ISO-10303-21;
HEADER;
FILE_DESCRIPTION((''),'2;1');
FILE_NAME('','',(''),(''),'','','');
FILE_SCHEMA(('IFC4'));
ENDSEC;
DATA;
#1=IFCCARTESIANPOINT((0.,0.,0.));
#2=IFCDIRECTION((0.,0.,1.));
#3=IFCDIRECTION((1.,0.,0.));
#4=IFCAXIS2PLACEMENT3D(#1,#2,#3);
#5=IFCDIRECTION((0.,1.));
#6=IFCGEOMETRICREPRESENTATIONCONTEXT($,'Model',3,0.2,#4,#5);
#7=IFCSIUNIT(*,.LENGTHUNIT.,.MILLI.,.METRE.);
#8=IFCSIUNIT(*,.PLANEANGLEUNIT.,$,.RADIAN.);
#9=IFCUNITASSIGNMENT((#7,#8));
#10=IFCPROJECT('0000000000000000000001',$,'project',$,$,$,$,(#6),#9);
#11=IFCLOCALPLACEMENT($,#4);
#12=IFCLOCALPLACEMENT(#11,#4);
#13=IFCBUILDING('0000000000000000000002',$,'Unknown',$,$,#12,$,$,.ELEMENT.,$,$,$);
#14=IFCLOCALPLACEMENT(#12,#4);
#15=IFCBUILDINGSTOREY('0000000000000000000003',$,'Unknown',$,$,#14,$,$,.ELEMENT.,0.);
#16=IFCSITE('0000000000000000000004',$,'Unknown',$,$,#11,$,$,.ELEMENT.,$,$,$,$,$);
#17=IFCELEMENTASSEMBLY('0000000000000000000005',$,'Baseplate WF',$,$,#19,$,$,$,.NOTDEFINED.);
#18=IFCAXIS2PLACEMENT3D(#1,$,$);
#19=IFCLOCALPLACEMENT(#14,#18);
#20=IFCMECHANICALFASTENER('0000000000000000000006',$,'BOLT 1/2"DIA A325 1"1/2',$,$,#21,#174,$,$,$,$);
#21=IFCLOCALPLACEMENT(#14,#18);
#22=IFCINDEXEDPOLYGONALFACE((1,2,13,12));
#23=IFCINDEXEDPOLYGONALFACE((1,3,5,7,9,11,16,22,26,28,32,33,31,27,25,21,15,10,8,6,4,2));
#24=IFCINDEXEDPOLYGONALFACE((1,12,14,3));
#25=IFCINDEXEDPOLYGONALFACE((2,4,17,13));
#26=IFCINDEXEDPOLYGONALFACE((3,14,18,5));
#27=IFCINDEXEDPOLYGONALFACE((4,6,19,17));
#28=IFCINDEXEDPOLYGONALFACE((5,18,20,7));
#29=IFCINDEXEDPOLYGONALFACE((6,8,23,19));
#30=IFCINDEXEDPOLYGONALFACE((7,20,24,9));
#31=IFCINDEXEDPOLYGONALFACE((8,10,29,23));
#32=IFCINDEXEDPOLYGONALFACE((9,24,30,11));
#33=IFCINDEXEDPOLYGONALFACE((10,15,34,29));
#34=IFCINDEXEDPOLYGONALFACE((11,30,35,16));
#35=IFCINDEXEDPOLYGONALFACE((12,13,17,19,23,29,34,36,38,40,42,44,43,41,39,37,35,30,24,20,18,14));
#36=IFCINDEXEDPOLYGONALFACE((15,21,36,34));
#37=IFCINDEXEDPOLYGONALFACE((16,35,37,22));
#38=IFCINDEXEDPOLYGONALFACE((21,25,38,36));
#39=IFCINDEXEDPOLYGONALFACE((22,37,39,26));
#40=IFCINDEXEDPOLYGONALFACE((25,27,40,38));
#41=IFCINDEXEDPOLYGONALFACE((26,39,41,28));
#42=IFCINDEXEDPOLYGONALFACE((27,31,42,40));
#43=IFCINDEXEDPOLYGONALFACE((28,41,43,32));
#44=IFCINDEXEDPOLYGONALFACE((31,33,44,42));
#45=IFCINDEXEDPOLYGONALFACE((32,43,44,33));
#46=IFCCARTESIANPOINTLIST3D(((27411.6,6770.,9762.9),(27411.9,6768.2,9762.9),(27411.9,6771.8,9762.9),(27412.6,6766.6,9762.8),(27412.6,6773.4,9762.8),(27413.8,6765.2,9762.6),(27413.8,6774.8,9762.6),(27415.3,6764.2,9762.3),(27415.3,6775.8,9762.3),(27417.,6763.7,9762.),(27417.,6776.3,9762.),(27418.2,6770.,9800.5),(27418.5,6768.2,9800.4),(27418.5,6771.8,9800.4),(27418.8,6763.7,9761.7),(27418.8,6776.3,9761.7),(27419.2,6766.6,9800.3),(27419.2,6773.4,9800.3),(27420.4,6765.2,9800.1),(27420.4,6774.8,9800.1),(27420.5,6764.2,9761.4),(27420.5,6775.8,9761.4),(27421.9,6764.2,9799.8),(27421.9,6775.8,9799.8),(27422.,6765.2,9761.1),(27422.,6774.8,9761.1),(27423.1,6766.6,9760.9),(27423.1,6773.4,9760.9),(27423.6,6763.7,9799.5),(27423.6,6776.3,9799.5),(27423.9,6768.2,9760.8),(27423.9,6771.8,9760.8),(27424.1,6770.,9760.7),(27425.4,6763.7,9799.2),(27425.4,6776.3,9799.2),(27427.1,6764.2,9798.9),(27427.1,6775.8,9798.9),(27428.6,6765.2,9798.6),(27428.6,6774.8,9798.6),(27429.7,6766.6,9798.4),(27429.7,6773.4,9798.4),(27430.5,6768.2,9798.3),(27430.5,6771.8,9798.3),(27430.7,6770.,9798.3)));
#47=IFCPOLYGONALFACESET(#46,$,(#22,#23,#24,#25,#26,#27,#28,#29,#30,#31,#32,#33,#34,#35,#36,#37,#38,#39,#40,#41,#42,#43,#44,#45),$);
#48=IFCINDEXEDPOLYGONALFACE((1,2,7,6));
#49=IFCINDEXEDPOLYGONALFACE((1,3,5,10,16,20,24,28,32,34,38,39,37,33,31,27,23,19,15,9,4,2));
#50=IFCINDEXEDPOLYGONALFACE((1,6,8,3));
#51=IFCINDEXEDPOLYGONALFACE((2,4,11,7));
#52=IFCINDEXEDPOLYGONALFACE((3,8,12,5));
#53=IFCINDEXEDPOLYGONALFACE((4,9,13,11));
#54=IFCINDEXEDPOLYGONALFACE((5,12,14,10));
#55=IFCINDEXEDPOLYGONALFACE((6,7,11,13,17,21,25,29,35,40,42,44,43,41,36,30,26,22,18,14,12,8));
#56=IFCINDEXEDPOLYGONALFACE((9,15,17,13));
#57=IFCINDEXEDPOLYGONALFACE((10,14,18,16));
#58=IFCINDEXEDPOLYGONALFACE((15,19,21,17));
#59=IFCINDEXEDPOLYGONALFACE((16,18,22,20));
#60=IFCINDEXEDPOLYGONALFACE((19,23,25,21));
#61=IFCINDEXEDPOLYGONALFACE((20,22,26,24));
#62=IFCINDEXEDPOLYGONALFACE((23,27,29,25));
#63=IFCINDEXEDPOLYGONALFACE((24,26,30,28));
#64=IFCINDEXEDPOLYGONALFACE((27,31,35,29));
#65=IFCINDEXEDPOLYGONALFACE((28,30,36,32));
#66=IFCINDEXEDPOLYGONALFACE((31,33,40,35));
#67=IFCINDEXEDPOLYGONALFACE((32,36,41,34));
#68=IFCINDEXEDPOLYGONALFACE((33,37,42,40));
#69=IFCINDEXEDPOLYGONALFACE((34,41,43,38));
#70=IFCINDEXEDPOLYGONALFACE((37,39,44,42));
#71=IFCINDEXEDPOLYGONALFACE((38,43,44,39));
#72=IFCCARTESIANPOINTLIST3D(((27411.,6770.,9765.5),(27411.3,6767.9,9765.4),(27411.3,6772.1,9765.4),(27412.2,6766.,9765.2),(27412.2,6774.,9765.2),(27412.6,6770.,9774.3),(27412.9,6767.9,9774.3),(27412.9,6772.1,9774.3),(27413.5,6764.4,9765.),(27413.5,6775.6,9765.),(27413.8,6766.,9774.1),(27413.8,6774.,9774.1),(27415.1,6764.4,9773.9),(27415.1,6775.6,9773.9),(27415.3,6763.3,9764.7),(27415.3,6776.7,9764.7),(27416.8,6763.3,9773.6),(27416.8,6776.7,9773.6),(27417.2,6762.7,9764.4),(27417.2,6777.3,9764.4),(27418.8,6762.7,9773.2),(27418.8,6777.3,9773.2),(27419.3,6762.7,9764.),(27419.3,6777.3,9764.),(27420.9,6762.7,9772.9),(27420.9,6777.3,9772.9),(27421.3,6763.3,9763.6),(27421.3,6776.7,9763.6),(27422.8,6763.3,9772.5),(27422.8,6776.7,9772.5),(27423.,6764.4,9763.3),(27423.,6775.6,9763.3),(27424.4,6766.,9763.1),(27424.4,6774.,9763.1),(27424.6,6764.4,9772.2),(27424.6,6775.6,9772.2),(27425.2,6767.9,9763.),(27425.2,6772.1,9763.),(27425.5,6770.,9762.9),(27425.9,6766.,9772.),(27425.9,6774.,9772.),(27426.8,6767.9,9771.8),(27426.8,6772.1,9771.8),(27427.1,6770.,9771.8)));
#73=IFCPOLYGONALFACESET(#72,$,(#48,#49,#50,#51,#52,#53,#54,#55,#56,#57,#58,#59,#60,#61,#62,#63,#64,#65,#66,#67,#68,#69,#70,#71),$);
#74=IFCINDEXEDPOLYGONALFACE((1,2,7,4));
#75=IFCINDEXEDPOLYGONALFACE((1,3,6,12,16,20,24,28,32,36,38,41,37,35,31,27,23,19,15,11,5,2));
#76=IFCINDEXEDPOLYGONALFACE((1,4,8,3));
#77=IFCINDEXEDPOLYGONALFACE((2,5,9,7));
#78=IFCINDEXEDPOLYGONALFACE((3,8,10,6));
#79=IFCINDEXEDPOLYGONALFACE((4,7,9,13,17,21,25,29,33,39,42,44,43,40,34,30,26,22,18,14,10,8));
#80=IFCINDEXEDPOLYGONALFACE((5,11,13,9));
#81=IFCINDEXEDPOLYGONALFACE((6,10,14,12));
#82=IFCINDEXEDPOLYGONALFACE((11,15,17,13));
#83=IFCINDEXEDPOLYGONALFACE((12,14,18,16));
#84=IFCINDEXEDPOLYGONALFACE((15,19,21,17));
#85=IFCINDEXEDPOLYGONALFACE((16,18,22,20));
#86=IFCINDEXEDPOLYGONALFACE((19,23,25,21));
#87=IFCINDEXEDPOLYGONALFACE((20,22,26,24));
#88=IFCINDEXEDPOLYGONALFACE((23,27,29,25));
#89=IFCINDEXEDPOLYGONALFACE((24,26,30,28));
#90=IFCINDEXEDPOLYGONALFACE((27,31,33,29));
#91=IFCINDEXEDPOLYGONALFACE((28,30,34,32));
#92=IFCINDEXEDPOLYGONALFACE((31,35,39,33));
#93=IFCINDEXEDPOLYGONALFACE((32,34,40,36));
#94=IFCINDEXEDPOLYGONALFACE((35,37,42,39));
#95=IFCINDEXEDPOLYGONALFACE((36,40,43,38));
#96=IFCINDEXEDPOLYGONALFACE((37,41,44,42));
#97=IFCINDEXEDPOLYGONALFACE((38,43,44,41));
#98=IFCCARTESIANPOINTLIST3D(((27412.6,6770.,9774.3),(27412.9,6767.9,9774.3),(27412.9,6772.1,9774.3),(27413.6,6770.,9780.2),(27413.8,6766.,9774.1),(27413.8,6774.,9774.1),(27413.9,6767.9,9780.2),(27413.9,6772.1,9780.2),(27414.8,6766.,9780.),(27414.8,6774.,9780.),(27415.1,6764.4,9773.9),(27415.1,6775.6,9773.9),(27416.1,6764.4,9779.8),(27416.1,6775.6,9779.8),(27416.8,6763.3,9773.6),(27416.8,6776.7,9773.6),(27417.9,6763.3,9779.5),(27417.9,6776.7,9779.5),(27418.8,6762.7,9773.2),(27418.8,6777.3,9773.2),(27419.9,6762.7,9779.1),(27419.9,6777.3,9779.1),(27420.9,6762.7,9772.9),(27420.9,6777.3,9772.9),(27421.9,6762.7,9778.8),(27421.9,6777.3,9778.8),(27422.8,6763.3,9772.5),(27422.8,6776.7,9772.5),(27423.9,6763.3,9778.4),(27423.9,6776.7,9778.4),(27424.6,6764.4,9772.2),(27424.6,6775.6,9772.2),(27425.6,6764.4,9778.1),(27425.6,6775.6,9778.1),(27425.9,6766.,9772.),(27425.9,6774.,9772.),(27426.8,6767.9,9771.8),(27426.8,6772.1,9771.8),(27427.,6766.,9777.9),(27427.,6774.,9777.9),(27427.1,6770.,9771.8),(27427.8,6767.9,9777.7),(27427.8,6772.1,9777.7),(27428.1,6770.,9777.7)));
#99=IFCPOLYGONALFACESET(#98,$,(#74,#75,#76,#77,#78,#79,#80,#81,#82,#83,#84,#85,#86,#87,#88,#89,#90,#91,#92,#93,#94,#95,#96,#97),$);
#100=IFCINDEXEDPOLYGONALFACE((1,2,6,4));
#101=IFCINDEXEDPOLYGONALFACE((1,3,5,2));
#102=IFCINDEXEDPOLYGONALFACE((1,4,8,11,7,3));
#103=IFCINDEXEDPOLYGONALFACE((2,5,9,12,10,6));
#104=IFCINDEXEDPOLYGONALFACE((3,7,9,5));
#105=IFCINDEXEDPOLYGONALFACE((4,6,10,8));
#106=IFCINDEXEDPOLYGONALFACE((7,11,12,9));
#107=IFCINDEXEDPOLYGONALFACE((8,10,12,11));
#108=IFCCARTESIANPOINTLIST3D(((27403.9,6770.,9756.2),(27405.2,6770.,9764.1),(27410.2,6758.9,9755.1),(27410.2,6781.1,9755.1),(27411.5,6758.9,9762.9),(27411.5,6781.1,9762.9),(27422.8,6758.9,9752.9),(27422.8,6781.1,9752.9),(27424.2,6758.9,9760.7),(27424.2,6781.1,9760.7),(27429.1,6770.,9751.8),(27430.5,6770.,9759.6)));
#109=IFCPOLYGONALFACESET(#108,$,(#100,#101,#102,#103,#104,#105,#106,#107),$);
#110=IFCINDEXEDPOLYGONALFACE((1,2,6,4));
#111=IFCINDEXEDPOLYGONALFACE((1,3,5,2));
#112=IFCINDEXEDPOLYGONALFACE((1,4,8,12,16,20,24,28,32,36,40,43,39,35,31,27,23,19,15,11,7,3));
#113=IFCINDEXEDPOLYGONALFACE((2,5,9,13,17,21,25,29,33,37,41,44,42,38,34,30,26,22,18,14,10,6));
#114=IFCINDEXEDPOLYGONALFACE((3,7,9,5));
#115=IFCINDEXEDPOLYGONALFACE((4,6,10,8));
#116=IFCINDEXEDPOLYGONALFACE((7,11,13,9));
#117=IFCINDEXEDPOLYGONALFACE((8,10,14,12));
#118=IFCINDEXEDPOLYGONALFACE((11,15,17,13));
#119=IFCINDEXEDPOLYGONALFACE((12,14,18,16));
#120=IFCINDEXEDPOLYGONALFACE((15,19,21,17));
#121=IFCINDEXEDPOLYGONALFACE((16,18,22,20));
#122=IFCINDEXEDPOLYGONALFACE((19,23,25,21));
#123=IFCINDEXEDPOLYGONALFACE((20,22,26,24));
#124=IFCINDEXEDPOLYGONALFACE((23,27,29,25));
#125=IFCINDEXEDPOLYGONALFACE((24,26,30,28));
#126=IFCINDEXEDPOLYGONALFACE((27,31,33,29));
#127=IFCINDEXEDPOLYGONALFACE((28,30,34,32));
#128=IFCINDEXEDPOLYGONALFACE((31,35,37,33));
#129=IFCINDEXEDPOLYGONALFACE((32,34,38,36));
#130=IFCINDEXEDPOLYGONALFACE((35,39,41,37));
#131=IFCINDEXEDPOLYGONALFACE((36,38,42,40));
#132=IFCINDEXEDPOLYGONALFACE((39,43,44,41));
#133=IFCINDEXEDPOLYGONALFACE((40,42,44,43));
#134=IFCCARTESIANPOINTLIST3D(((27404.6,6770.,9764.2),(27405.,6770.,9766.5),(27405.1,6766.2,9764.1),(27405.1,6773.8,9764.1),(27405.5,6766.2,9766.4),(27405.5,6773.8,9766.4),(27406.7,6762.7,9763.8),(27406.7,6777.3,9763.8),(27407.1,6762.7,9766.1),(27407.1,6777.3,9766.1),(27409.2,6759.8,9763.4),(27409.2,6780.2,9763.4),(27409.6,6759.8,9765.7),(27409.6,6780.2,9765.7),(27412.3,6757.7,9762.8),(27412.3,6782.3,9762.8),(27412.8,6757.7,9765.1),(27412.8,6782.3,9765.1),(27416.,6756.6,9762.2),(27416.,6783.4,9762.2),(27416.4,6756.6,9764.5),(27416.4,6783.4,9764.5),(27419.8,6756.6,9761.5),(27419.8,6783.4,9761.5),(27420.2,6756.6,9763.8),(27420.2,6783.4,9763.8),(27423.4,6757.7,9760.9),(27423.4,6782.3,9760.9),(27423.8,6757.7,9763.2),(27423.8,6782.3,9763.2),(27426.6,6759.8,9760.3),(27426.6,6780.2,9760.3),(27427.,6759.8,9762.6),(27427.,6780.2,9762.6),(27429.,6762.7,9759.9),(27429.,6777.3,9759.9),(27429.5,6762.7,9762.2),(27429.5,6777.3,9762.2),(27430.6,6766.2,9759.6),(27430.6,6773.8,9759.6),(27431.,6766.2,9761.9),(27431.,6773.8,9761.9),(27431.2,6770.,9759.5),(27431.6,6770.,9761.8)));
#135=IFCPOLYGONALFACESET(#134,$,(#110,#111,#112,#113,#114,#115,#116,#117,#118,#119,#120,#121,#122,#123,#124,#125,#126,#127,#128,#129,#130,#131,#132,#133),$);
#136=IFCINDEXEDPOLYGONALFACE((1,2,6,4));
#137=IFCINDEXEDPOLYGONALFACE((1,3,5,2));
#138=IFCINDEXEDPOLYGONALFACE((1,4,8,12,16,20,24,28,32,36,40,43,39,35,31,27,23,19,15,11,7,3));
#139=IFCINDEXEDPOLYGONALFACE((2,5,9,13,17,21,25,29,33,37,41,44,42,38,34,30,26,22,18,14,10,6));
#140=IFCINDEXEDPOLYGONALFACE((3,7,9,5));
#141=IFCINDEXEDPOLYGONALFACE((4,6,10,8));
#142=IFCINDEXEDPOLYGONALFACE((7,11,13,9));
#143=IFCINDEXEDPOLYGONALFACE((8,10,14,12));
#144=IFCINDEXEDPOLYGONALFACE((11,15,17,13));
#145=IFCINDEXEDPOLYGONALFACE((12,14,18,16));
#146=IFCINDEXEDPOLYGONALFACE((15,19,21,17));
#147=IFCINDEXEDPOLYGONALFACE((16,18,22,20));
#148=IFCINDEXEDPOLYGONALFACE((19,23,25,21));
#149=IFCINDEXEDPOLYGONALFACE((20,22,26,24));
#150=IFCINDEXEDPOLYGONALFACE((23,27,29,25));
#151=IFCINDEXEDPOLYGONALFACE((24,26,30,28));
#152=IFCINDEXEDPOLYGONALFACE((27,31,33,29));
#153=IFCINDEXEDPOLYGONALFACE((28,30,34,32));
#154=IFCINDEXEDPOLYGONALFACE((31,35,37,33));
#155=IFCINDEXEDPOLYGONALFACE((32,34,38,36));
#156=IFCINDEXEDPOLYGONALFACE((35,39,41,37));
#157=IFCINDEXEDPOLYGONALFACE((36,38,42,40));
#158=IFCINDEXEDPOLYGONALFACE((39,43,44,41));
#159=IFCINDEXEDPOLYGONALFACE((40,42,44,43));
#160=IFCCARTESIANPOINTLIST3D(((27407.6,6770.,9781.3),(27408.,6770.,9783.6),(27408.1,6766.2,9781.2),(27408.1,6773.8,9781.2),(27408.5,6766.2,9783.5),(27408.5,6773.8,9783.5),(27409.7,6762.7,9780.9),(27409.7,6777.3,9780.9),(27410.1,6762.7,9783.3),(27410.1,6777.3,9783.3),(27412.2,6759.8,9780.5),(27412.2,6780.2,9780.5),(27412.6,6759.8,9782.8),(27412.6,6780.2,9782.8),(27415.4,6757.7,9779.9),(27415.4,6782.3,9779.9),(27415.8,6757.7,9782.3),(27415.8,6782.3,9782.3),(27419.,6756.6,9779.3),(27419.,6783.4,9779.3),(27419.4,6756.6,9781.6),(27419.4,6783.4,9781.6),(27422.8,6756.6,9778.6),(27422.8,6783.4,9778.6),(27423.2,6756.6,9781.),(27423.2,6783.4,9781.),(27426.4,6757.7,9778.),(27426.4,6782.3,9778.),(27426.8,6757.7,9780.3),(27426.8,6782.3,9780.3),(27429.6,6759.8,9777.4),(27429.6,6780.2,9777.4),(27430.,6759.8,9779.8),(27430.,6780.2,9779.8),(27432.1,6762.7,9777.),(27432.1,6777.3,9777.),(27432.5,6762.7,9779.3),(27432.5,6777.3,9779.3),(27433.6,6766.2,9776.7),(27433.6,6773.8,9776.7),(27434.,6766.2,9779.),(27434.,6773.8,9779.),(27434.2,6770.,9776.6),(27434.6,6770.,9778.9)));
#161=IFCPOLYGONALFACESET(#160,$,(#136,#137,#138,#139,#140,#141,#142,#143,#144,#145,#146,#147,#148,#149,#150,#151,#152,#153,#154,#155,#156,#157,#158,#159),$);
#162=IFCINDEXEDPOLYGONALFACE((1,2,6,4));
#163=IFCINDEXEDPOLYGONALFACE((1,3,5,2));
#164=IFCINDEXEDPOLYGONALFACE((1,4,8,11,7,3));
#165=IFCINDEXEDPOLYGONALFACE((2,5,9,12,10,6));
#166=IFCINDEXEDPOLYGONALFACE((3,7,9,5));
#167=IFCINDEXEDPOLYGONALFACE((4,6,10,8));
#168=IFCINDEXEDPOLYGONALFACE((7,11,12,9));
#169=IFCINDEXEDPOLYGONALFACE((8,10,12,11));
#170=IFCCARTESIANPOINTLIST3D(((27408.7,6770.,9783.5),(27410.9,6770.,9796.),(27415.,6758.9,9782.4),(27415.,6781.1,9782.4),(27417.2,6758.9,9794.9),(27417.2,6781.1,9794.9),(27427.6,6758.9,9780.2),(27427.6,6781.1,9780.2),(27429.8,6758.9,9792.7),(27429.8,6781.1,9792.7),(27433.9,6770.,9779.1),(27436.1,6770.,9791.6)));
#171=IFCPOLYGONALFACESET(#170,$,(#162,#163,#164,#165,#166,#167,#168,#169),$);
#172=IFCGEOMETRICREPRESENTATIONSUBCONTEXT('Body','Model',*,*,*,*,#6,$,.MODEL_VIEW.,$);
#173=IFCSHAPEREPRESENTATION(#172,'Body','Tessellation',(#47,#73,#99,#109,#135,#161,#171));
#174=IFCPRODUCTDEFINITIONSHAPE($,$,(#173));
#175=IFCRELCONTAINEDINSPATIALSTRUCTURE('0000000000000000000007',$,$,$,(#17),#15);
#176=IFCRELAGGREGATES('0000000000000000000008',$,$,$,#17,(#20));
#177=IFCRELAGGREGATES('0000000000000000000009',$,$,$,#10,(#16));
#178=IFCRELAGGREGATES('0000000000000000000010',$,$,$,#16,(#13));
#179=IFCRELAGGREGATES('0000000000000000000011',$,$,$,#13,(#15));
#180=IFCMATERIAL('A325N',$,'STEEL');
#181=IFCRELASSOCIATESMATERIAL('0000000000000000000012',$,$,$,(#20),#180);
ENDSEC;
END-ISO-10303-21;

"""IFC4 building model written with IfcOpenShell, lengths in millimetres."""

from ifc_helpers import new_model, si_unit, direction, frame, origin_with_axes, place, context, subcontext, project, spatial, line, arc, indexed_curve, outline, extrude, source, transform, mapped, material, element, aggregate, save


model = new_model("IFC4")

# Units and contexts
model_context = context("Model", 3, precision=0.2, world=origin_with_axes(), true_north=direction((0.0, 1.0)))
body_context = subcontext(model_context, "Body", "Model", "MODEL_VIEW")
ifc_project = project(units=[si_unit("LENGTHUNIT", "METRE", prefix="MILLI"), si_unit("PLANEANGLEUNIT", "RADIAN")], contexts=[model_context])

# Site, building, storey
site_placement = place(None, origin_with_axes())
site = spatial("IfcSite", under=ifc_project, at=site_placement, Name="Unknown", CompositionType="ELEMENT")
building_placement = place(site_placement, origin_with_axes())
building = spatial("IfcBuilding", under=site, at=building_placement, Name="Unknown", CompositionType="ELEMENT")
storey_placement = place(building_placement, origin_with_axes())
storey = spatial("IfcBuildingStorey", under=building, at=storey_placement, Name="Unknown", CompositionType="ELEMENT", Elevation=0.0)

# Shared definitions
ifc_material_1 = material(Name="A325N", Category="STEEL")
shared_shape_1 = source(origin_with_axes(), body_context, "Body", "SweptSolid", [
    extrude(outline(indexed_curve([(6.3, 0.0), (0.0, 6.3), (-6.3, 0.0), (0.0, -6.3)], segments=[arc(1, 2, 3), arc(3, 4, 1)])), frame((0.0, 0.0, 17.4), z_axis=(0.0, 0.0, -1.0), x_axis=(0.0, 1.0, 0.0)), (0.0, 0.0, 1.0), 38.1),
    extrude(outline(indexed_curve([(7.3, 0.0), (0.0, 7.3), (-7.3, 0.0), (0.0, -7.3)], segments=[arc(1, 2, 3), arc(3, 4, 1)])), frame((0.0, 0.0, 15.0), z_axis=(0.0, 0.0, -1.0), x_axis=(0.0, 1.0, 0.0)), (0.0, 0.0, 1.0), 9.0),
    extrude(outline(indexed_curve([(7.3, 0.0), (0.0, 7.3), (-7.3, 0.0), (0.0, -7.3)], segments=[arc(1, 2, 3), arc(3, 4, 1)])), frame((0.0, 0.0, 6.0), z_axis=(0.0, 0.0, -1.0), x_axis=(0.0, 1.0, 0.0)), (0.0, 0.0, 1.0), 6.0),
    extrude(outline(indexed_curve([(12.8, 0.0), (6.4, 11.1), (-6.4, 11.1), (-12.8, 0.0), (-6.4, -11.1), (6.4, -11.1)], segments=[line(1, 2, 3, 4, 5, 6, 1)])), frame((0.0, 0.0, 25.3), z_axis=(0.0, 0.0, -1.0), x_axis=(0.0, 1.0, 0.0)), (0.0, 0.0, 1.0), 7.9),
    extrude(outline(indexed_curve([(13.5, 0.0), (0.0, 13.5), (-13.5, 0.0), (0.0, -13.5)], segments=[arc(1, 2, 3), arc(3, 4, 1)])), frame((0.0, 0.0, 17.4), z_axis=(0.0, 0.0, -1.0), x_axis=(0.0, 1.0, 0.0)), (0.0, 0.0, 1.0), 2.4),
    extrude(outline(indexed_curve([(13.5, 0.0), (0.0, 13.5), (-13.5, 0.0), (0.0, -13.5)], segments=[arc(1, 2, 3), arc(3, 4, 1)])), frame((0.0, 0.0, 0.0), z_axis=(0.0, 0.0, -1.0), x_axis=(0.0, 1.0, 0.0)), (0.0, 0.0, 1.0), 2.4),
    extrude(outline(indexed_curve([(12.8, 0.0), (6.4, 11.1), (-6.4, 11.1), (-12.8, 0.0), (-6.4, -11.1), (6.4, -11.1)], segments=[line(1, 2, 3, 4, 5, 6, 1)])), frame((0.0, 0.0, -2.4), z_axis=(0.0, 0.0, -1.0), x_axis=(0.0, 1.0, 0.0)), (0.0, 0.0, 1.0), 12.7),
])

# Element assembly, mechanical fastener
assembly_1_placement = place(storey_placement, frame((27449.9, 6800.0, 9770.8), z_axis=(-0.173648, 0.0, -0.984808), x_axis=(0.0, -1.0, 0.0)))
assembly_1 = element("IfcElementAssembly", 1, at=assembly_1_placement, inside=storey, Name="Baseplate WF", PredefinedType="NOTDEFINED")
mechanical_fastener_1_placement = place(assembly_1_placement, frame((30.0, 30.0, -3.0), z_axis=(0.0, 0.0, 1.0), x_axis=(1.0, 0.0, 0.0)))
mechanical_fastener_1 = element("IfcMechanicalFastener", 2, at=mechanical_fastener_1_placement, material=ifc_material_1, Name="BOLT 1/2\"DIA A325 1\"1/2", context=body_context, shape_type="MappedRepresentation", body=[
    mapped(shared_shape_1, transform((0.0, 0.0, 0.0))),
])
aggregate(assembly_1, [mechanical_fastener_1])

save(model, "model.ifc")
